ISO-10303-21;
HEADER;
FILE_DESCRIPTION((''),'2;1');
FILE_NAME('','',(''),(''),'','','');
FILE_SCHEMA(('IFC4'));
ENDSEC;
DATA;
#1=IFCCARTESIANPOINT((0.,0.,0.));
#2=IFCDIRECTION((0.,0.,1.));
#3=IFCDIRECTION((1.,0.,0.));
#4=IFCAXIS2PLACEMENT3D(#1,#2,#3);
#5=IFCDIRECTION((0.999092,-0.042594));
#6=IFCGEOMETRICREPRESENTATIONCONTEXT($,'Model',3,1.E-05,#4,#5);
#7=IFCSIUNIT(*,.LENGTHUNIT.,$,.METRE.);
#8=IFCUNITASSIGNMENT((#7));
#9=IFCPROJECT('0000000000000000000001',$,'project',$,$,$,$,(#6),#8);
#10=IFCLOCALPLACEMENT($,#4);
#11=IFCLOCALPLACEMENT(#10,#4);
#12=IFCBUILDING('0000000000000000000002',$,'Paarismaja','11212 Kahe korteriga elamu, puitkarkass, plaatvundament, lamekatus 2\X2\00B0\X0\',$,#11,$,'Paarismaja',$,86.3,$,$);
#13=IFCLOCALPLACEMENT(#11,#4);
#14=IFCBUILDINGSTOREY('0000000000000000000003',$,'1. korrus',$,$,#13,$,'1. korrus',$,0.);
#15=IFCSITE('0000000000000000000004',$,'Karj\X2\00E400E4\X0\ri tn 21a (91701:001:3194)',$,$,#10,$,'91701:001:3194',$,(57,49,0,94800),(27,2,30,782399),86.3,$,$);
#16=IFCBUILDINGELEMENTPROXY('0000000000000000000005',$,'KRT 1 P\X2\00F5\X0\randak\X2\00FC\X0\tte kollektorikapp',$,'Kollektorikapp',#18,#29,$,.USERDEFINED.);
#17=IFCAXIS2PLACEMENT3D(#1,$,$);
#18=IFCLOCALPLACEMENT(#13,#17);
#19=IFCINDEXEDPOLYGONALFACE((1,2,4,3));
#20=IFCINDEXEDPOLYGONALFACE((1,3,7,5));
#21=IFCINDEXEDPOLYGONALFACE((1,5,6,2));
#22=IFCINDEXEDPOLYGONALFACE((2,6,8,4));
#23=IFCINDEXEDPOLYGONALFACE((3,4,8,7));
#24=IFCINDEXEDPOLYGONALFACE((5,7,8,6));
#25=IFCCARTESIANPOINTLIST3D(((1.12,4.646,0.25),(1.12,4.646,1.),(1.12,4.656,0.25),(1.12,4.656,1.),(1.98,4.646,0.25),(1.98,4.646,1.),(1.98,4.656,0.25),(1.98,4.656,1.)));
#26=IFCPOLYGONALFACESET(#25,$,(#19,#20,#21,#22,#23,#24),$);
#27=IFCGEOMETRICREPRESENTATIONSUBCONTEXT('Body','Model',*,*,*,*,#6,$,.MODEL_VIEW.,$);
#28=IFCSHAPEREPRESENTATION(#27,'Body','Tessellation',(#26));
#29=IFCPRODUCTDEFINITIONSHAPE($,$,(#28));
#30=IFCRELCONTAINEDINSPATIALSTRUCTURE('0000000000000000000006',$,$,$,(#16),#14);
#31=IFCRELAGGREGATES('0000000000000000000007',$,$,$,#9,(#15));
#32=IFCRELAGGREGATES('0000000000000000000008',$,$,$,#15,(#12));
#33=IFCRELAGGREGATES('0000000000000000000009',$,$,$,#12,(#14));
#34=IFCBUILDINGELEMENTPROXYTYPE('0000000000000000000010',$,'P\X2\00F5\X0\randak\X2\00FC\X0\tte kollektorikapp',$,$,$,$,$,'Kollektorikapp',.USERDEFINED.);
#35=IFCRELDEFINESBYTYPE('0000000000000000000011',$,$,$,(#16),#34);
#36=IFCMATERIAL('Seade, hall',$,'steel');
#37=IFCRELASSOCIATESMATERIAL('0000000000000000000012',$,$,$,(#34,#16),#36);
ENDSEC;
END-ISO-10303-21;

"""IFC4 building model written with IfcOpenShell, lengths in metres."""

from ifc_helpers import new_model, si_unit, direction, frame, origin_with_axes, place, context, subcontext, project, spatial, indexed_curve, outline, extrude, material, type_object, element, save


model = new_model("IFC4")

# Units and contexts
model_context = context("Model", 3, precision=1e-05, world=origin_with_axes(), true_north=direction((0.999092, -0.042594)))
body_context = subcontext(model_context, "Body", "Model", "MODEL_VIEW")
ifc_project = project(units=[si_unit("LENGTHUNIT", "METRE")], contexts=[model_context])

# Site, building, storey
site_placement = place(None, origin_with_axes())
site = spatial("IfcSite", under=ifc_project, at=site_placement, Name="Karjääri tn 21a (91701:001:3194)", LongName="91701:001:3194", RefLatitude=(57, 49, 0, 94800), RefLongitude=(27, 2, 30, 782399), RefElevation=86.3)
building_placement = place(site_placement, origin_with_axes())
building = spatial("IfcBuilding", under=site, at=building_placement, Name="Paarismaja", Description="11212 Kahe korteriga elamu, puitkarkass, plaatvundament, lamekatus 2°", LongName="Paarismaja", ElevationOfRefHeight=86.3)
storey_placement = place(building_placement, origin_with_axes())
storey = spatial("IfcBuildingStorey", under=building, at=storey_placement, Name="1. korrus", LongName="1. korrus", Elevation=0.0)

# Shared definitions
ifc_material_1 = material(Name="Seade, hall", Category="steel")

# Building element proxy
building_element_proxy_type_1 = type_object("IfcBuildingElementProxyType", Name="Põrandakütte kollektorikapp", ElementType="Kollektorikapp", PredefinedType="USERDEFINED", material=ifc_material_1)
proxy_1_placement = place(storey_placement, origin_with_axes())
element("IfcBuildingElementProxy", 1, at=proxy_1_placement, inside=storey, type_object=building_element_proxy_type_1, material=ifc_material_1, Name="KRT 1 Põrandakütte kollektorikapp", ObjectType="Kollektorikapp", PredefinedType="USERDEFINED", context=body_context, shape_type="SweptSolid", body=[
    extrude(outline(indexed_curve([(1.12, 4.646), (1.98, 4.646), (1.98, 4.656), (1.12, 4.656), (1.12, 4.646)], self_intersect=False)), frame((0.0, 0.0, 0.25), z_axis=(0.0, 0.0, 1.0), x_axis=(1.0, 0.0, 0.0)), (0.0, 0.0, 1.0), 0.75),
])

save(model, "model.ifc")
